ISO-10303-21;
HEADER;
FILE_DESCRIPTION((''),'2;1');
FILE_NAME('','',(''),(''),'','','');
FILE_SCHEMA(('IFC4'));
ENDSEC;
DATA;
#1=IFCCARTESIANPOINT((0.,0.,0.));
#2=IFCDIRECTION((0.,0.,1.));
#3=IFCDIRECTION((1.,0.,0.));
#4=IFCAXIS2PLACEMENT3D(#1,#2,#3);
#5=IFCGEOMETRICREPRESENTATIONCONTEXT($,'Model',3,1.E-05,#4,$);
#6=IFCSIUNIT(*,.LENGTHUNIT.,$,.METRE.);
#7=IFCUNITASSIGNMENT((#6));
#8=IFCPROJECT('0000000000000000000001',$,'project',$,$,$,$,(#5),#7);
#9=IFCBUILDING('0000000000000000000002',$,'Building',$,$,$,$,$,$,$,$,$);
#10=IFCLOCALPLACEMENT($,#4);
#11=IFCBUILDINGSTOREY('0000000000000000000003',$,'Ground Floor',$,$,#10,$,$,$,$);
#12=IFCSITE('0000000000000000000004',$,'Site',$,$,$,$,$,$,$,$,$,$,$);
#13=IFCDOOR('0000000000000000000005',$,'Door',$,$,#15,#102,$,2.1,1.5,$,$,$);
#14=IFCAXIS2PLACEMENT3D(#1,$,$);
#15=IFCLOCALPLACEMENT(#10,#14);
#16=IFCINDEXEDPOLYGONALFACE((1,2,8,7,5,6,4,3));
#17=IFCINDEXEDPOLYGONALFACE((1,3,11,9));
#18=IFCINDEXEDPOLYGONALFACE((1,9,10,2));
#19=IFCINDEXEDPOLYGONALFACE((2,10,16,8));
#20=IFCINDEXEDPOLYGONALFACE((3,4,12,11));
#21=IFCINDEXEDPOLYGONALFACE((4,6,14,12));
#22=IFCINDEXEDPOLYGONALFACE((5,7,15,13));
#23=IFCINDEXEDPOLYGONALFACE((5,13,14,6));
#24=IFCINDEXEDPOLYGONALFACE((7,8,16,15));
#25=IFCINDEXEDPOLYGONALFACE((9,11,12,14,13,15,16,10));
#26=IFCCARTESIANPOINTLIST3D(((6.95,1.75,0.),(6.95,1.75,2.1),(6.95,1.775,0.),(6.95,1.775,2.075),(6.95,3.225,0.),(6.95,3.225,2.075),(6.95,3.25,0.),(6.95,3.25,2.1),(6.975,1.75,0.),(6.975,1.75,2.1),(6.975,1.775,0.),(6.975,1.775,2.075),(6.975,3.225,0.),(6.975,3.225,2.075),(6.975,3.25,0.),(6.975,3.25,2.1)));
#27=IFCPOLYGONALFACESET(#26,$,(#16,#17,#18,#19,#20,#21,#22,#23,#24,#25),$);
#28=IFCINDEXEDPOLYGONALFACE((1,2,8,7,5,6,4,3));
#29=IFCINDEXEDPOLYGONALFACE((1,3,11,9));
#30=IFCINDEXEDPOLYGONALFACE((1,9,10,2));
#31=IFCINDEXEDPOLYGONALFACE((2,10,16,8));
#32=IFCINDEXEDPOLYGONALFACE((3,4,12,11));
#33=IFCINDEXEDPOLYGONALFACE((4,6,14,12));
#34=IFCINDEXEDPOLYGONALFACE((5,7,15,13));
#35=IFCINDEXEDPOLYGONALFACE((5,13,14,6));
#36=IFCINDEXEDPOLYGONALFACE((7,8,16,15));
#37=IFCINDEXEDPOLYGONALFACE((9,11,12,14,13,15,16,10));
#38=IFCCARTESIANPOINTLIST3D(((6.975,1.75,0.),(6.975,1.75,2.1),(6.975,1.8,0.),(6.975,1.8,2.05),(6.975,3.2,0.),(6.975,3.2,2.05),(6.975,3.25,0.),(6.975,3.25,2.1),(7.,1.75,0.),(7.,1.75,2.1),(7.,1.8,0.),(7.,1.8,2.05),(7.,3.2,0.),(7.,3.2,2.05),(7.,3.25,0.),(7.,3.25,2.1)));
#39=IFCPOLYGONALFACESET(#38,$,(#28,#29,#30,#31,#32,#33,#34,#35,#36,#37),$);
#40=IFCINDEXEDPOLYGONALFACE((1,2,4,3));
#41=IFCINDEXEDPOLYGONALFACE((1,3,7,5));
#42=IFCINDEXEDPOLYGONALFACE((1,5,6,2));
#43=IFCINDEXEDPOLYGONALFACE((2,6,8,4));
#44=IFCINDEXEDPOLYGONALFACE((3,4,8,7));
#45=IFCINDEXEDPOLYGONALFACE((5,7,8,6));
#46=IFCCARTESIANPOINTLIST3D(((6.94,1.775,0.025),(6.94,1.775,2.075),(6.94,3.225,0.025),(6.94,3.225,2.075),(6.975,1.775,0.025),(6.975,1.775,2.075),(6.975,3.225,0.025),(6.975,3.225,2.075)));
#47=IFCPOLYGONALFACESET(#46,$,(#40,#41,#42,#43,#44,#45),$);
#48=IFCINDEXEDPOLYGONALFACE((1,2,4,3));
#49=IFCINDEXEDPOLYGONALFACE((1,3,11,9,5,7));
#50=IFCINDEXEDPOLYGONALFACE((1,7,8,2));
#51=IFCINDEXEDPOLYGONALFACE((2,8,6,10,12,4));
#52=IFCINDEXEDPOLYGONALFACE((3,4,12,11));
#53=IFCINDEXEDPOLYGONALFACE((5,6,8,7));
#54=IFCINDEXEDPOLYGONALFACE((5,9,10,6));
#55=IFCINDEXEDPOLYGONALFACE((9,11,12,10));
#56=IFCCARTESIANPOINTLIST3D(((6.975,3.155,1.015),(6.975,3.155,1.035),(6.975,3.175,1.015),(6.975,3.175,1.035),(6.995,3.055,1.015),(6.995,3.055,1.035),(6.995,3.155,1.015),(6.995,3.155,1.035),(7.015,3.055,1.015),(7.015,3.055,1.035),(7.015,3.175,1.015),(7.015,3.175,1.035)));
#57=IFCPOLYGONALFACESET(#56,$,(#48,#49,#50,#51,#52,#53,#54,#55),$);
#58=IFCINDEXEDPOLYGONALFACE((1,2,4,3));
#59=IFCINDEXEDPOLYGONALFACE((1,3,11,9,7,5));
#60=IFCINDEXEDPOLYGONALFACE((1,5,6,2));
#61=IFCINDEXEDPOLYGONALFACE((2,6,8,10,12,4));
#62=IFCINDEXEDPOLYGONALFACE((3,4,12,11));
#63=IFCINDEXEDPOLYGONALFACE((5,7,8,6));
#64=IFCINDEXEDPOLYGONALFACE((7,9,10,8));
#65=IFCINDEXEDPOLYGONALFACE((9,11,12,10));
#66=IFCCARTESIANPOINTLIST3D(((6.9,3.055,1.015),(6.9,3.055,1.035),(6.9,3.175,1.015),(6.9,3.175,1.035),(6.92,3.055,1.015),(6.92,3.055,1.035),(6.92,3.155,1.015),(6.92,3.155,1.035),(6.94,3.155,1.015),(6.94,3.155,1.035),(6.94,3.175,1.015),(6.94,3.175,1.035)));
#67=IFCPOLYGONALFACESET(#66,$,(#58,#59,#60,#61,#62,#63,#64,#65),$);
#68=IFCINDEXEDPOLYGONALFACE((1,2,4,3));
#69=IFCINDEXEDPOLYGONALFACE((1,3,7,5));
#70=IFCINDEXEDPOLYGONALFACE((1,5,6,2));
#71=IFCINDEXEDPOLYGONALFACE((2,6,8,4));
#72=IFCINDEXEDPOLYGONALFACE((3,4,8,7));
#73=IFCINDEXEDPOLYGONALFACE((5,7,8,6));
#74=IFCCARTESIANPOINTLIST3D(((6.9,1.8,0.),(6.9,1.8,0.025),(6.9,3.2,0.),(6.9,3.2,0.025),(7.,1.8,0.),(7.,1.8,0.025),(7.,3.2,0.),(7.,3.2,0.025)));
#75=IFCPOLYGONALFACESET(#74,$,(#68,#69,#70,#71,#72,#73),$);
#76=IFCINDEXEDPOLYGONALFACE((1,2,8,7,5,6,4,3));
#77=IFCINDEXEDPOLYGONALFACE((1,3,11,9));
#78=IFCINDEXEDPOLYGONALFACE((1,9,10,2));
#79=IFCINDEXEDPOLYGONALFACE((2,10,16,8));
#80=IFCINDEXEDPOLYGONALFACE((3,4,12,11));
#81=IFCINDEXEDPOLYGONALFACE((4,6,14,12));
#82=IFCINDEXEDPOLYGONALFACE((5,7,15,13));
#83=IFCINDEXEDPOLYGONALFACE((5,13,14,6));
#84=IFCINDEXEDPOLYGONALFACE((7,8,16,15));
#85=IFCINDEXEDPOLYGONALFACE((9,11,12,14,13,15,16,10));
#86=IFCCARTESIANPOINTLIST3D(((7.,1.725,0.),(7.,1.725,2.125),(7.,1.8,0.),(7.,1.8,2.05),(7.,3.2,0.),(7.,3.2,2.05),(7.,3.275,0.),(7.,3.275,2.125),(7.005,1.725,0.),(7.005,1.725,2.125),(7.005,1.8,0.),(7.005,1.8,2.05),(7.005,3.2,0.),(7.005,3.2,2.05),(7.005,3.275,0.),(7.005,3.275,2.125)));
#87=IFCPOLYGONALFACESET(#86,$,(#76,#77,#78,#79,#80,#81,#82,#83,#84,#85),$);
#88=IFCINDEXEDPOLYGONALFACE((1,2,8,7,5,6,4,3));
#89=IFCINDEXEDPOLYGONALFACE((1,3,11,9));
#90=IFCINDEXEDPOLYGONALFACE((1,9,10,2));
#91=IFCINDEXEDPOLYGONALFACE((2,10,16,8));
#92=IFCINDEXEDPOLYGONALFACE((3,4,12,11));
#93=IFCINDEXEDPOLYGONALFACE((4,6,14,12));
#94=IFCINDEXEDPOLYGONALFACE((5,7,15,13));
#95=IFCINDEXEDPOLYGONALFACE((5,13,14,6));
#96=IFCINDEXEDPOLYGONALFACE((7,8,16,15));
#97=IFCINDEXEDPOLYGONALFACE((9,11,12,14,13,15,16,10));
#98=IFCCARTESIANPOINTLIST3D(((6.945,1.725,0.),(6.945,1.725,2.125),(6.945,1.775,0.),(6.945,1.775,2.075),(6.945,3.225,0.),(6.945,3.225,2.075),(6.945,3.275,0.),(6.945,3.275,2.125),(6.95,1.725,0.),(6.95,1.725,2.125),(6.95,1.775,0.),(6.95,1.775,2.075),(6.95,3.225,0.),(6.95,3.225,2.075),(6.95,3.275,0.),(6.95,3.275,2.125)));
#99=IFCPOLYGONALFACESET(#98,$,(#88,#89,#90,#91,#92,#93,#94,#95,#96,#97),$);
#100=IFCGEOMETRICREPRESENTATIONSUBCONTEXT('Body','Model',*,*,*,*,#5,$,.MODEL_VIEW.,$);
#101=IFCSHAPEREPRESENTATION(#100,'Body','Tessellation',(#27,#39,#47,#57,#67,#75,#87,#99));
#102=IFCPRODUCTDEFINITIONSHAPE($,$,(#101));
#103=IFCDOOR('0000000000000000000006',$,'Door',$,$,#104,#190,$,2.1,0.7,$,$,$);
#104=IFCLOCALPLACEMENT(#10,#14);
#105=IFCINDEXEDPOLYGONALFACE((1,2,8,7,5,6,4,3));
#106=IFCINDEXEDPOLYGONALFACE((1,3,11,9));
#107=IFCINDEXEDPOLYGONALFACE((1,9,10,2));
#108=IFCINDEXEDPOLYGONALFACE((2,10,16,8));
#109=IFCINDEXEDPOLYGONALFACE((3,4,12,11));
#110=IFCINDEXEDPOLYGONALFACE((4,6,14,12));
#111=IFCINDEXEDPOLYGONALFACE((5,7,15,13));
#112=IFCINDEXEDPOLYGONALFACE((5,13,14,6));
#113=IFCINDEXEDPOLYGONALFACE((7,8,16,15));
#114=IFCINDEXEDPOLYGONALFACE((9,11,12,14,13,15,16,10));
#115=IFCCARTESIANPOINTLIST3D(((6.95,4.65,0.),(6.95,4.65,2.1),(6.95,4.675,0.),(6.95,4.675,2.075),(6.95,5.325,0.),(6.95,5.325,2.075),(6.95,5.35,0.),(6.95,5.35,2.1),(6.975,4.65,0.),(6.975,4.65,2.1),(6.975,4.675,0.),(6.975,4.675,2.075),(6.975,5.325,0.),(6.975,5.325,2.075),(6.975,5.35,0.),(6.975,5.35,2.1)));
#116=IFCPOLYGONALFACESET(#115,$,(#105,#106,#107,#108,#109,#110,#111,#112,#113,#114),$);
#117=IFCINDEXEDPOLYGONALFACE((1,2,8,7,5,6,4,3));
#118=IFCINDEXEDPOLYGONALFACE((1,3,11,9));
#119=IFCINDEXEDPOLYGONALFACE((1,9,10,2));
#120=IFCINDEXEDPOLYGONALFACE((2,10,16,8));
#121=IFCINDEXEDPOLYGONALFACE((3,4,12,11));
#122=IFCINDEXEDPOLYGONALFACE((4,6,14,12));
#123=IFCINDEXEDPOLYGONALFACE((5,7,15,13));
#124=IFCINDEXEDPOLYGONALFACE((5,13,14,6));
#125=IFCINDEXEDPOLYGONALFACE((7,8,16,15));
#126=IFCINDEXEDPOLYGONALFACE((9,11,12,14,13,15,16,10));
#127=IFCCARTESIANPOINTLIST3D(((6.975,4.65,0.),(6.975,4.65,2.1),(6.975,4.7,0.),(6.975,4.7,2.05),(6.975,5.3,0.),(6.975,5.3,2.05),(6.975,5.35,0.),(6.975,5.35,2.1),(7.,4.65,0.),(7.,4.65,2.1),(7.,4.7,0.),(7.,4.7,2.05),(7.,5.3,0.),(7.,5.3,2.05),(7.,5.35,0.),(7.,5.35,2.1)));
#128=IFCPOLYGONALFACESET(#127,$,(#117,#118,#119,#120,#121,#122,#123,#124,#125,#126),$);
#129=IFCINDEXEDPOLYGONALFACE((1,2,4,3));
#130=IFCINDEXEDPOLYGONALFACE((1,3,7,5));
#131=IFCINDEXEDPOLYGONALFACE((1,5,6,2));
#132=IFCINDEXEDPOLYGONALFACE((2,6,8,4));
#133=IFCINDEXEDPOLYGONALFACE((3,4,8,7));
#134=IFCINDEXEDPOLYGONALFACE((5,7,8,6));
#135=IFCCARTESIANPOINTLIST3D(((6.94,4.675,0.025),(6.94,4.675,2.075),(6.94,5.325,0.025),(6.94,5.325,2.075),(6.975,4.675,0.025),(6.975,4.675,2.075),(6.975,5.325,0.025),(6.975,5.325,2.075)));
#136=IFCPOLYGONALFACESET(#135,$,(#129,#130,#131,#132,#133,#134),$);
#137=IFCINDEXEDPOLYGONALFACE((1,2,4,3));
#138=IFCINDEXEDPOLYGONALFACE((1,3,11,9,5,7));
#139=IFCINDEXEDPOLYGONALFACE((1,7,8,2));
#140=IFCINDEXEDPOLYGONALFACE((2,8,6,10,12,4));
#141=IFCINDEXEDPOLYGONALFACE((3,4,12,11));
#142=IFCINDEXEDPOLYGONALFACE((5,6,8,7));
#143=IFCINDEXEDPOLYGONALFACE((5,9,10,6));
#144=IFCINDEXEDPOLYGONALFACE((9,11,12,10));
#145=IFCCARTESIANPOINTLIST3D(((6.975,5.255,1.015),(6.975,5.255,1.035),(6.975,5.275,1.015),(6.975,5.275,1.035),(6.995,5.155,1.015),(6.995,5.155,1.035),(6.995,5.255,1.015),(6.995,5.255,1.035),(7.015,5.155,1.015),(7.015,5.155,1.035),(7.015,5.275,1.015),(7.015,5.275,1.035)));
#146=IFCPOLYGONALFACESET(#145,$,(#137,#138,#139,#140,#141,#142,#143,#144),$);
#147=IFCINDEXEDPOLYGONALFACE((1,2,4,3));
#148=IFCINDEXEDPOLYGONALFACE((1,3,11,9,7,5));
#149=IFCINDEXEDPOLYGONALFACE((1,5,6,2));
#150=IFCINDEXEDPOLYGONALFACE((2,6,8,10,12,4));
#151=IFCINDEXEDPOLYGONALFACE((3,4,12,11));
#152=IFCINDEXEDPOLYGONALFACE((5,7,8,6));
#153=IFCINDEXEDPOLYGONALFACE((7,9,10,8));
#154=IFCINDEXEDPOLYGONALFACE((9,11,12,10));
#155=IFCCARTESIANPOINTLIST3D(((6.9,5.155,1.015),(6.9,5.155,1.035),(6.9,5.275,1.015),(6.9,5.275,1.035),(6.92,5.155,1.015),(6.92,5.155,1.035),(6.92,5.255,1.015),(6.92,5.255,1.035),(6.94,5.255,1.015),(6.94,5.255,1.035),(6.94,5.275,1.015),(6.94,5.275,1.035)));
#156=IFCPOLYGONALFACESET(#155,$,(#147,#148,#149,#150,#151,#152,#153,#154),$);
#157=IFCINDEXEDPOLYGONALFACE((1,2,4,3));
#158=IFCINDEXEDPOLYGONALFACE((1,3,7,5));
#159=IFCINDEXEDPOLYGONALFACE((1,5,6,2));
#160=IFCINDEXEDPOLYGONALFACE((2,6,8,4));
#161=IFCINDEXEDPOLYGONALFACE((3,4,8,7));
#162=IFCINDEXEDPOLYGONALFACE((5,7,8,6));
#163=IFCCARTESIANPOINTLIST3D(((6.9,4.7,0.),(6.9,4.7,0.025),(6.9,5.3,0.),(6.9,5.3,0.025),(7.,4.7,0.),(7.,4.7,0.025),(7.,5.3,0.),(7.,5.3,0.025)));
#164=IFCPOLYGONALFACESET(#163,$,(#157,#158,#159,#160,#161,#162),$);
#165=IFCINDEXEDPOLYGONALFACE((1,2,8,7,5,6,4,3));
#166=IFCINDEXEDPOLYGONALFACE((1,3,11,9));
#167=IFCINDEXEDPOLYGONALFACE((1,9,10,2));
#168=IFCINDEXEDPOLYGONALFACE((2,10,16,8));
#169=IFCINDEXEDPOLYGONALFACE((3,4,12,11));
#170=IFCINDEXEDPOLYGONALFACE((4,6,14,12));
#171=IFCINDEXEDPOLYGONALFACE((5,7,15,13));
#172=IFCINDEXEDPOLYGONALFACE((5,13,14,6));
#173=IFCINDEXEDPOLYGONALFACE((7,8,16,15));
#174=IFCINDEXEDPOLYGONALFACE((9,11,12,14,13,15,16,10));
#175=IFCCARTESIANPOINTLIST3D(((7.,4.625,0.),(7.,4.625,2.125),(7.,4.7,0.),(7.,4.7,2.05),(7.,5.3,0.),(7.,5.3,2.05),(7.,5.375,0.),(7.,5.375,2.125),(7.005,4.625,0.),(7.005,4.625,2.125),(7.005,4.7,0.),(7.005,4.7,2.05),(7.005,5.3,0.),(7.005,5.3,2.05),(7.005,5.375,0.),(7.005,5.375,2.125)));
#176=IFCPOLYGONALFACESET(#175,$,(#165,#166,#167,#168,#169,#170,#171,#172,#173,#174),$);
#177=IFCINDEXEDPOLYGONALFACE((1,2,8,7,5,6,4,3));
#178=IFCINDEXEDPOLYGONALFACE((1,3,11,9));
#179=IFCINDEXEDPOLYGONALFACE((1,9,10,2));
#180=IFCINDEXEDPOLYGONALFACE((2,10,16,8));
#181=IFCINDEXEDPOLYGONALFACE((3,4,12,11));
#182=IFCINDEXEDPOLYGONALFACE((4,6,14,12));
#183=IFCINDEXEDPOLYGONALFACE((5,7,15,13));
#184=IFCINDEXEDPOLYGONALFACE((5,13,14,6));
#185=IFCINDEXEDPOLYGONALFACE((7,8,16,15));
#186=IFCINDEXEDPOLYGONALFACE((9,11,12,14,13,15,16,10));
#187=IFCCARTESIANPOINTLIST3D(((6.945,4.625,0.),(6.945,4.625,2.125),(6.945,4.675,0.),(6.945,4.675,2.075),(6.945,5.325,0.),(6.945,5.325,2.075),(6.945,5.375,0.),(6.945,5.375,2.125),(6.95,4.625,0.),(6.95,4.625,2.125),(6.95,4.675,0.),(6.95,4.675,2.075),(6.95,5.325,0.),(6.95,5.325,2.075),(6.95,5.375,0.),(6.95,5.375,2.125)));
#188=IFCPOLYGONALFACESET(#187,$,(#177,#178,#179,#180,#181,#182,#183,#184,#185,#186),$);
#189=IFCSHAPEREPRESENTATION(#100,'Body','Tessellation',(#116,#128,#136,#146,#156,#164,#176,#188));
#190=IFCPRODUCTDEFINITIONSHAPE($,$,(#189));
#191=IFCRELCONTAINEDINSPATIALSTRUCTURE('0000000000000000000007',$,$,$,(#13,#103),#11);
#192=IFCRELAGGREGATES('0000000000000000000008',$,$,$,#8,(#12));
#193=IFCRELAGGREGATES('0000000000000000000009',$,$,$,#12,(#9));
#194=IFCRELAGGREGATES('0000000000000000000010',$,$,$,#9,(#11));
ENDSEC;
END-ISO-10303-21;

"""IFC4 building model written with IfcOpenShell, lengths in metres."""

from ifc_helpers import new_model, si_unit, frame, origin_with_axes, place, context, subcontext, project, spatial, line, indexed_curve, outline, extrude, element, save


model = new_model("IFC4")

# Units and contexts
model_context = context("Model", 3, precision=1e-05, world=origin_with_axes())
body_context = subcontext(model_context, "Body", "Model", "MODEL_VIEW")
ifc_project = project(units=[si_unit("LENGTHUNIT", "METRE")], contexts=[model_context])

# Site, building, storey
site = spatial("IfcSite", under=ifc_project, Name="Site")
building = spatial("IfcBuilding", under=site, Name="Building")
storey_placement = place(None, origin_with_axes())
storey = spatial("IfcBuildingStorey", under=building, at=storey_placement, Name="Ground Floor")

# Doors
door_1_placement = place(storey_placement, frame((7.0, 1.75, 0.0), z_axis=(0.0, 0.0, 1.0), x_axis=(0.0, 1.0, 0.0)))
element("IfcDoor", 1, at=door_1_placement, inside=storey, Name="Door", OverallHeight=2.1, OverallWidth=1.5, context=body_context, shape_type="SweptSolid", body=[
    extrude(outline(indexed_curve([(0.0, 0.0), (0.0, 2.1), (1.5, 2.1), (1.5, 0.0), (1.475, 0.0), (1.475, 2.075), (0.025, 2.075), (0.025, 0.0)], segments=[line(1, 2, 3, 4, 5, 6, 7, 8, 1)])), frame((0.0, 0.025, 0.0), z_axis=(0.0, -1.0, 0.0), x_axis=(1.0, 0.0, 0.0)), (0.0, 0.0, -1.0), 0.025),
    extrude(outline(indexed_curve([(0.0, 0.0), (0.0, 2.1), (1.5, 2.1), (1.5, 0.0), (1.45, 0.0), (1.45, 2.05), (0.05, 2.05), (0.05, 0.0)], segments=[line(1, 2, 3, 4, 5, 6, 7, 8, 1)])), frame((0.0, 0.0, 0.0), z_axis=(0.0, -1.0, 0.0), x_axis=(1.0, 0.0, 0.0)), (0.0, 0.0, -1.0), 0.025),
    extrude(outline(indexed_curve([(0.0, 0.0), (1.45, 0.0), (1.45, 0.035), (0.0, 0.035)], segments=[line(1, 2, 3, 4, 1)])), frame((0.025, 0.025, 0.025), z_axis=(0.0, 0.0, 1.0), x_axis=(1.0, 0.0, 0.0)), (0.0, 0.0, 1.0), 2.05),
    extrude(outline(indexed_curve([(0.0, 0.0), (0.0, -0.04), (-0.12, -0.04), (-0.12, -0.02), (-0.02, -0.02), (-0.02, 0.0)], segments=[line(1, 2, 3, 4, 5, 6, 1)])), frame((1.425, 0.025, 1.015), z_axis=(0.0, 0.0, 1.0), x_axis=(1.0, 0.0, 0.0)), (0.0, 0.0, 1.0), 0.02),
    extrude(outline(indexed_curve([(0.0, 0.0), (0.0, 0.04), (-0.12, 0.04), (-0.12, 0.02), (-0.02, 0.02), (-0.02, 0.0)], segments=[line(1, 2, 3, 4, 5, 6, 1)])), frame((1.425, 0.06, 1.015), z_axis=(0.0, 0.0, 1.0), x_axis=(1.0, 0.0, 0.0)), (0.0, 0.0, 1.0), 0.02),
    extrude(outline(indexed_curve([(0.0, 0.0), (1.4, 0.0), (1.4, 0.1), (0.0, 0.1)], segments=[line(1, 2, 3, 4, 1)])), frame((0.05, 0.0, 0.0), z_axis=(0.0, 0.0, 1.0), x_axis=(1.0, 0.0, 0.0)), (0.0, 0.0, 1.0), 0.025),
    extrude(outline(indexed_curve([(0.0, 0.0), (0.0, 2.125), (1.55, 2.125), (1.55, 0.0), (1.475, 0.0), (1.475, 2.05), (0.075, 2.05), (0.075, 0.0)], segments=[line(1, 2, 3, 4, 5, 6, 7, 8, 1)])), frame((-0.025, -0.005, 0.0), z_axis=(0.0, -1.0, 0.0), x_axis=(1.0, 0.0, 0.0)), (0.0, 0.0, -1.0), 0.005),
    extrude(outline(indexed_curve([(0.0, 0.0), (0.0, 2.125), (1.55, 2.125), (1.55, 0.0), (1.5, 0.0), (1.5, 2.075), (0.05, 2.075), (0.05, 0.0)], segments=[line(1, 2, 3, 4, 5, 6, 7, 8, 1)])), frame((-0.025, 0.05, 0.0), z_axis=(0.0, -1.0, 0.0), x_axis=(1.0, 0.0, 0.0)), (0.0, 0.0, -1.0), 0.005),
])
door_2_placement = place(storey_placement, frame((7.0, 4.65, 0.0), z_axis=(0.0, 0.0, 1.0), x_axis=(0.0, 1.0, 0.0)))
element("IfcDoor", 2, at=door_2_placement, inside=storey, Name="Door", OverallHeight=2.1, OverallWidth=0.7, context=body_context, shape_type="SweptSolid", body=[
    extrude(outline(indexed_curve([(0.0, 0.0), (0.0, 2.1), (0.7, 2.1), (0.7, 0.0), (0.675, 0.0), (0.675, 2.075), (0.025, 2.075), (0.025, 0.0)], segments=[line(1, 2, 3, 4, 5, 6, 7, 8, 1)])), frame((0.0, 0.025, 0.0), z_axis=(0.0, -1.0, 0.0), x_axis=(1.0, 0.0, 0.0)), (0.0, 0.0, -1.0), 0.025),
    extrude(outline(indexed_curve([(0.0, 0.0), (0.0, 2.1), (0.7, 2.1), (0.7, 0.0), (0.65, 0.0), (0.65, 2.05), (0.05, 2.05), (0.05, 0.0)], segments=[line(1, 2, 3, 4, 5, 6, 7, 8, 1)])), frame((0.0, 0.0, 0.0), z_axis=(0.0, -1.0, 0.0), x_axis=(1.0, 0.0, 0.0)), (0.0, 0.0, -1.0), 0.025),
    extrude(outline(indexed_curve([(0.0, 0.0), (0.65, 0.0), (0.65, 0.035), (0.0, 0.035)], segments=[line(1, 2, 3, 4, 1)])), frame((0.025, 0.025, 0.025), z_axis=(0.0, 0.0, 1.0), x_axis=(1.0, 0.0, 0.0)), (0.0, 0.0, 1.0), 2.05),
    extrude(outline(indexed_curve([(0.0, 0.0), (0.0, -0.04), (-0.12, -0.04), (-0.12, -0.02), (-0.02, -0.02), (-0.02, 0.0)], segments=[line(1, 2, 3, 4, 5, 6, 1)])), frame((0.625, 0.025, 1.015), z_axis=(0.0, 0.0, 1.0), x_axis=(1.0, 0.0, 0.0)), (0.0, 0.0, 1.0), 0.02),
    extrude(outline(indexed_curve([(0.0, 0.0), (0.0, 0.04), (-0.12, 0.04), (-0.12, 0.02), (-0.02, 0.02), (-0.02, 0.0)], segments=[line(1, 2, 3, 4, 5, 6, 1)])), frame((0.625, 0.06, 1.015), z_axis=(0.0, 0.0, 1.0), x_axis=(1.0, 0.0, 0.0)), (0.0, 0.0, 1.0), 0.02),
    extrude(outline(indexed_curve([(0.0, 0.0), (0.6, 0.0), (0.6, 0.1), (0.0, 0.1)], segments=[line(1, 2, 3, 4, 1)])), frame((0.05, 0.0, 0.0), z_axis=(0.0, 0.0, 1.0), x_axis=(1.0, 0.0, 0.0)), (0.0, 0.0, 1.0), 0.025),
    extrude(outline(indexed_curve([(0.0, 0.0), (0.0, 2.125), (0.75, 2.125), (0.75, 0.0), (0.675, 0.0), (0.675, 2.05), (0.075, 2.05), (0.075, 0.0)], segments=[line(1, 2, 3, 4, 5, 6, 7, 8, 1)])), frame((-0.025, -0.005, 0.0), z_axis=(0.0, -1.0, 0.0), x_axis=(1.0, 0.0, 0.0)), (0.0, 0.0, -1.0), 0.005),
    extrude(outline(indexed_curve([(0.0, 0.0), (0.0, 2.125), (0.75, 2.125), (0.75, 0.0), (0.7, 0.0), (0.7, 2.075), (0.05, 2.075), (0.05, 0.0)], segments=[line(1, 2, 3, 4, 5, 6, 7, 8, 1)])), frame((-0.025, 0.05, 0.0), z_axis=(0.0, -1.0, 0.0), x_axis=(1.0, 0.0, 0.0)), (0.0, 0.0, -1.0), 0.005),
])

save(model, "model.ifc")
